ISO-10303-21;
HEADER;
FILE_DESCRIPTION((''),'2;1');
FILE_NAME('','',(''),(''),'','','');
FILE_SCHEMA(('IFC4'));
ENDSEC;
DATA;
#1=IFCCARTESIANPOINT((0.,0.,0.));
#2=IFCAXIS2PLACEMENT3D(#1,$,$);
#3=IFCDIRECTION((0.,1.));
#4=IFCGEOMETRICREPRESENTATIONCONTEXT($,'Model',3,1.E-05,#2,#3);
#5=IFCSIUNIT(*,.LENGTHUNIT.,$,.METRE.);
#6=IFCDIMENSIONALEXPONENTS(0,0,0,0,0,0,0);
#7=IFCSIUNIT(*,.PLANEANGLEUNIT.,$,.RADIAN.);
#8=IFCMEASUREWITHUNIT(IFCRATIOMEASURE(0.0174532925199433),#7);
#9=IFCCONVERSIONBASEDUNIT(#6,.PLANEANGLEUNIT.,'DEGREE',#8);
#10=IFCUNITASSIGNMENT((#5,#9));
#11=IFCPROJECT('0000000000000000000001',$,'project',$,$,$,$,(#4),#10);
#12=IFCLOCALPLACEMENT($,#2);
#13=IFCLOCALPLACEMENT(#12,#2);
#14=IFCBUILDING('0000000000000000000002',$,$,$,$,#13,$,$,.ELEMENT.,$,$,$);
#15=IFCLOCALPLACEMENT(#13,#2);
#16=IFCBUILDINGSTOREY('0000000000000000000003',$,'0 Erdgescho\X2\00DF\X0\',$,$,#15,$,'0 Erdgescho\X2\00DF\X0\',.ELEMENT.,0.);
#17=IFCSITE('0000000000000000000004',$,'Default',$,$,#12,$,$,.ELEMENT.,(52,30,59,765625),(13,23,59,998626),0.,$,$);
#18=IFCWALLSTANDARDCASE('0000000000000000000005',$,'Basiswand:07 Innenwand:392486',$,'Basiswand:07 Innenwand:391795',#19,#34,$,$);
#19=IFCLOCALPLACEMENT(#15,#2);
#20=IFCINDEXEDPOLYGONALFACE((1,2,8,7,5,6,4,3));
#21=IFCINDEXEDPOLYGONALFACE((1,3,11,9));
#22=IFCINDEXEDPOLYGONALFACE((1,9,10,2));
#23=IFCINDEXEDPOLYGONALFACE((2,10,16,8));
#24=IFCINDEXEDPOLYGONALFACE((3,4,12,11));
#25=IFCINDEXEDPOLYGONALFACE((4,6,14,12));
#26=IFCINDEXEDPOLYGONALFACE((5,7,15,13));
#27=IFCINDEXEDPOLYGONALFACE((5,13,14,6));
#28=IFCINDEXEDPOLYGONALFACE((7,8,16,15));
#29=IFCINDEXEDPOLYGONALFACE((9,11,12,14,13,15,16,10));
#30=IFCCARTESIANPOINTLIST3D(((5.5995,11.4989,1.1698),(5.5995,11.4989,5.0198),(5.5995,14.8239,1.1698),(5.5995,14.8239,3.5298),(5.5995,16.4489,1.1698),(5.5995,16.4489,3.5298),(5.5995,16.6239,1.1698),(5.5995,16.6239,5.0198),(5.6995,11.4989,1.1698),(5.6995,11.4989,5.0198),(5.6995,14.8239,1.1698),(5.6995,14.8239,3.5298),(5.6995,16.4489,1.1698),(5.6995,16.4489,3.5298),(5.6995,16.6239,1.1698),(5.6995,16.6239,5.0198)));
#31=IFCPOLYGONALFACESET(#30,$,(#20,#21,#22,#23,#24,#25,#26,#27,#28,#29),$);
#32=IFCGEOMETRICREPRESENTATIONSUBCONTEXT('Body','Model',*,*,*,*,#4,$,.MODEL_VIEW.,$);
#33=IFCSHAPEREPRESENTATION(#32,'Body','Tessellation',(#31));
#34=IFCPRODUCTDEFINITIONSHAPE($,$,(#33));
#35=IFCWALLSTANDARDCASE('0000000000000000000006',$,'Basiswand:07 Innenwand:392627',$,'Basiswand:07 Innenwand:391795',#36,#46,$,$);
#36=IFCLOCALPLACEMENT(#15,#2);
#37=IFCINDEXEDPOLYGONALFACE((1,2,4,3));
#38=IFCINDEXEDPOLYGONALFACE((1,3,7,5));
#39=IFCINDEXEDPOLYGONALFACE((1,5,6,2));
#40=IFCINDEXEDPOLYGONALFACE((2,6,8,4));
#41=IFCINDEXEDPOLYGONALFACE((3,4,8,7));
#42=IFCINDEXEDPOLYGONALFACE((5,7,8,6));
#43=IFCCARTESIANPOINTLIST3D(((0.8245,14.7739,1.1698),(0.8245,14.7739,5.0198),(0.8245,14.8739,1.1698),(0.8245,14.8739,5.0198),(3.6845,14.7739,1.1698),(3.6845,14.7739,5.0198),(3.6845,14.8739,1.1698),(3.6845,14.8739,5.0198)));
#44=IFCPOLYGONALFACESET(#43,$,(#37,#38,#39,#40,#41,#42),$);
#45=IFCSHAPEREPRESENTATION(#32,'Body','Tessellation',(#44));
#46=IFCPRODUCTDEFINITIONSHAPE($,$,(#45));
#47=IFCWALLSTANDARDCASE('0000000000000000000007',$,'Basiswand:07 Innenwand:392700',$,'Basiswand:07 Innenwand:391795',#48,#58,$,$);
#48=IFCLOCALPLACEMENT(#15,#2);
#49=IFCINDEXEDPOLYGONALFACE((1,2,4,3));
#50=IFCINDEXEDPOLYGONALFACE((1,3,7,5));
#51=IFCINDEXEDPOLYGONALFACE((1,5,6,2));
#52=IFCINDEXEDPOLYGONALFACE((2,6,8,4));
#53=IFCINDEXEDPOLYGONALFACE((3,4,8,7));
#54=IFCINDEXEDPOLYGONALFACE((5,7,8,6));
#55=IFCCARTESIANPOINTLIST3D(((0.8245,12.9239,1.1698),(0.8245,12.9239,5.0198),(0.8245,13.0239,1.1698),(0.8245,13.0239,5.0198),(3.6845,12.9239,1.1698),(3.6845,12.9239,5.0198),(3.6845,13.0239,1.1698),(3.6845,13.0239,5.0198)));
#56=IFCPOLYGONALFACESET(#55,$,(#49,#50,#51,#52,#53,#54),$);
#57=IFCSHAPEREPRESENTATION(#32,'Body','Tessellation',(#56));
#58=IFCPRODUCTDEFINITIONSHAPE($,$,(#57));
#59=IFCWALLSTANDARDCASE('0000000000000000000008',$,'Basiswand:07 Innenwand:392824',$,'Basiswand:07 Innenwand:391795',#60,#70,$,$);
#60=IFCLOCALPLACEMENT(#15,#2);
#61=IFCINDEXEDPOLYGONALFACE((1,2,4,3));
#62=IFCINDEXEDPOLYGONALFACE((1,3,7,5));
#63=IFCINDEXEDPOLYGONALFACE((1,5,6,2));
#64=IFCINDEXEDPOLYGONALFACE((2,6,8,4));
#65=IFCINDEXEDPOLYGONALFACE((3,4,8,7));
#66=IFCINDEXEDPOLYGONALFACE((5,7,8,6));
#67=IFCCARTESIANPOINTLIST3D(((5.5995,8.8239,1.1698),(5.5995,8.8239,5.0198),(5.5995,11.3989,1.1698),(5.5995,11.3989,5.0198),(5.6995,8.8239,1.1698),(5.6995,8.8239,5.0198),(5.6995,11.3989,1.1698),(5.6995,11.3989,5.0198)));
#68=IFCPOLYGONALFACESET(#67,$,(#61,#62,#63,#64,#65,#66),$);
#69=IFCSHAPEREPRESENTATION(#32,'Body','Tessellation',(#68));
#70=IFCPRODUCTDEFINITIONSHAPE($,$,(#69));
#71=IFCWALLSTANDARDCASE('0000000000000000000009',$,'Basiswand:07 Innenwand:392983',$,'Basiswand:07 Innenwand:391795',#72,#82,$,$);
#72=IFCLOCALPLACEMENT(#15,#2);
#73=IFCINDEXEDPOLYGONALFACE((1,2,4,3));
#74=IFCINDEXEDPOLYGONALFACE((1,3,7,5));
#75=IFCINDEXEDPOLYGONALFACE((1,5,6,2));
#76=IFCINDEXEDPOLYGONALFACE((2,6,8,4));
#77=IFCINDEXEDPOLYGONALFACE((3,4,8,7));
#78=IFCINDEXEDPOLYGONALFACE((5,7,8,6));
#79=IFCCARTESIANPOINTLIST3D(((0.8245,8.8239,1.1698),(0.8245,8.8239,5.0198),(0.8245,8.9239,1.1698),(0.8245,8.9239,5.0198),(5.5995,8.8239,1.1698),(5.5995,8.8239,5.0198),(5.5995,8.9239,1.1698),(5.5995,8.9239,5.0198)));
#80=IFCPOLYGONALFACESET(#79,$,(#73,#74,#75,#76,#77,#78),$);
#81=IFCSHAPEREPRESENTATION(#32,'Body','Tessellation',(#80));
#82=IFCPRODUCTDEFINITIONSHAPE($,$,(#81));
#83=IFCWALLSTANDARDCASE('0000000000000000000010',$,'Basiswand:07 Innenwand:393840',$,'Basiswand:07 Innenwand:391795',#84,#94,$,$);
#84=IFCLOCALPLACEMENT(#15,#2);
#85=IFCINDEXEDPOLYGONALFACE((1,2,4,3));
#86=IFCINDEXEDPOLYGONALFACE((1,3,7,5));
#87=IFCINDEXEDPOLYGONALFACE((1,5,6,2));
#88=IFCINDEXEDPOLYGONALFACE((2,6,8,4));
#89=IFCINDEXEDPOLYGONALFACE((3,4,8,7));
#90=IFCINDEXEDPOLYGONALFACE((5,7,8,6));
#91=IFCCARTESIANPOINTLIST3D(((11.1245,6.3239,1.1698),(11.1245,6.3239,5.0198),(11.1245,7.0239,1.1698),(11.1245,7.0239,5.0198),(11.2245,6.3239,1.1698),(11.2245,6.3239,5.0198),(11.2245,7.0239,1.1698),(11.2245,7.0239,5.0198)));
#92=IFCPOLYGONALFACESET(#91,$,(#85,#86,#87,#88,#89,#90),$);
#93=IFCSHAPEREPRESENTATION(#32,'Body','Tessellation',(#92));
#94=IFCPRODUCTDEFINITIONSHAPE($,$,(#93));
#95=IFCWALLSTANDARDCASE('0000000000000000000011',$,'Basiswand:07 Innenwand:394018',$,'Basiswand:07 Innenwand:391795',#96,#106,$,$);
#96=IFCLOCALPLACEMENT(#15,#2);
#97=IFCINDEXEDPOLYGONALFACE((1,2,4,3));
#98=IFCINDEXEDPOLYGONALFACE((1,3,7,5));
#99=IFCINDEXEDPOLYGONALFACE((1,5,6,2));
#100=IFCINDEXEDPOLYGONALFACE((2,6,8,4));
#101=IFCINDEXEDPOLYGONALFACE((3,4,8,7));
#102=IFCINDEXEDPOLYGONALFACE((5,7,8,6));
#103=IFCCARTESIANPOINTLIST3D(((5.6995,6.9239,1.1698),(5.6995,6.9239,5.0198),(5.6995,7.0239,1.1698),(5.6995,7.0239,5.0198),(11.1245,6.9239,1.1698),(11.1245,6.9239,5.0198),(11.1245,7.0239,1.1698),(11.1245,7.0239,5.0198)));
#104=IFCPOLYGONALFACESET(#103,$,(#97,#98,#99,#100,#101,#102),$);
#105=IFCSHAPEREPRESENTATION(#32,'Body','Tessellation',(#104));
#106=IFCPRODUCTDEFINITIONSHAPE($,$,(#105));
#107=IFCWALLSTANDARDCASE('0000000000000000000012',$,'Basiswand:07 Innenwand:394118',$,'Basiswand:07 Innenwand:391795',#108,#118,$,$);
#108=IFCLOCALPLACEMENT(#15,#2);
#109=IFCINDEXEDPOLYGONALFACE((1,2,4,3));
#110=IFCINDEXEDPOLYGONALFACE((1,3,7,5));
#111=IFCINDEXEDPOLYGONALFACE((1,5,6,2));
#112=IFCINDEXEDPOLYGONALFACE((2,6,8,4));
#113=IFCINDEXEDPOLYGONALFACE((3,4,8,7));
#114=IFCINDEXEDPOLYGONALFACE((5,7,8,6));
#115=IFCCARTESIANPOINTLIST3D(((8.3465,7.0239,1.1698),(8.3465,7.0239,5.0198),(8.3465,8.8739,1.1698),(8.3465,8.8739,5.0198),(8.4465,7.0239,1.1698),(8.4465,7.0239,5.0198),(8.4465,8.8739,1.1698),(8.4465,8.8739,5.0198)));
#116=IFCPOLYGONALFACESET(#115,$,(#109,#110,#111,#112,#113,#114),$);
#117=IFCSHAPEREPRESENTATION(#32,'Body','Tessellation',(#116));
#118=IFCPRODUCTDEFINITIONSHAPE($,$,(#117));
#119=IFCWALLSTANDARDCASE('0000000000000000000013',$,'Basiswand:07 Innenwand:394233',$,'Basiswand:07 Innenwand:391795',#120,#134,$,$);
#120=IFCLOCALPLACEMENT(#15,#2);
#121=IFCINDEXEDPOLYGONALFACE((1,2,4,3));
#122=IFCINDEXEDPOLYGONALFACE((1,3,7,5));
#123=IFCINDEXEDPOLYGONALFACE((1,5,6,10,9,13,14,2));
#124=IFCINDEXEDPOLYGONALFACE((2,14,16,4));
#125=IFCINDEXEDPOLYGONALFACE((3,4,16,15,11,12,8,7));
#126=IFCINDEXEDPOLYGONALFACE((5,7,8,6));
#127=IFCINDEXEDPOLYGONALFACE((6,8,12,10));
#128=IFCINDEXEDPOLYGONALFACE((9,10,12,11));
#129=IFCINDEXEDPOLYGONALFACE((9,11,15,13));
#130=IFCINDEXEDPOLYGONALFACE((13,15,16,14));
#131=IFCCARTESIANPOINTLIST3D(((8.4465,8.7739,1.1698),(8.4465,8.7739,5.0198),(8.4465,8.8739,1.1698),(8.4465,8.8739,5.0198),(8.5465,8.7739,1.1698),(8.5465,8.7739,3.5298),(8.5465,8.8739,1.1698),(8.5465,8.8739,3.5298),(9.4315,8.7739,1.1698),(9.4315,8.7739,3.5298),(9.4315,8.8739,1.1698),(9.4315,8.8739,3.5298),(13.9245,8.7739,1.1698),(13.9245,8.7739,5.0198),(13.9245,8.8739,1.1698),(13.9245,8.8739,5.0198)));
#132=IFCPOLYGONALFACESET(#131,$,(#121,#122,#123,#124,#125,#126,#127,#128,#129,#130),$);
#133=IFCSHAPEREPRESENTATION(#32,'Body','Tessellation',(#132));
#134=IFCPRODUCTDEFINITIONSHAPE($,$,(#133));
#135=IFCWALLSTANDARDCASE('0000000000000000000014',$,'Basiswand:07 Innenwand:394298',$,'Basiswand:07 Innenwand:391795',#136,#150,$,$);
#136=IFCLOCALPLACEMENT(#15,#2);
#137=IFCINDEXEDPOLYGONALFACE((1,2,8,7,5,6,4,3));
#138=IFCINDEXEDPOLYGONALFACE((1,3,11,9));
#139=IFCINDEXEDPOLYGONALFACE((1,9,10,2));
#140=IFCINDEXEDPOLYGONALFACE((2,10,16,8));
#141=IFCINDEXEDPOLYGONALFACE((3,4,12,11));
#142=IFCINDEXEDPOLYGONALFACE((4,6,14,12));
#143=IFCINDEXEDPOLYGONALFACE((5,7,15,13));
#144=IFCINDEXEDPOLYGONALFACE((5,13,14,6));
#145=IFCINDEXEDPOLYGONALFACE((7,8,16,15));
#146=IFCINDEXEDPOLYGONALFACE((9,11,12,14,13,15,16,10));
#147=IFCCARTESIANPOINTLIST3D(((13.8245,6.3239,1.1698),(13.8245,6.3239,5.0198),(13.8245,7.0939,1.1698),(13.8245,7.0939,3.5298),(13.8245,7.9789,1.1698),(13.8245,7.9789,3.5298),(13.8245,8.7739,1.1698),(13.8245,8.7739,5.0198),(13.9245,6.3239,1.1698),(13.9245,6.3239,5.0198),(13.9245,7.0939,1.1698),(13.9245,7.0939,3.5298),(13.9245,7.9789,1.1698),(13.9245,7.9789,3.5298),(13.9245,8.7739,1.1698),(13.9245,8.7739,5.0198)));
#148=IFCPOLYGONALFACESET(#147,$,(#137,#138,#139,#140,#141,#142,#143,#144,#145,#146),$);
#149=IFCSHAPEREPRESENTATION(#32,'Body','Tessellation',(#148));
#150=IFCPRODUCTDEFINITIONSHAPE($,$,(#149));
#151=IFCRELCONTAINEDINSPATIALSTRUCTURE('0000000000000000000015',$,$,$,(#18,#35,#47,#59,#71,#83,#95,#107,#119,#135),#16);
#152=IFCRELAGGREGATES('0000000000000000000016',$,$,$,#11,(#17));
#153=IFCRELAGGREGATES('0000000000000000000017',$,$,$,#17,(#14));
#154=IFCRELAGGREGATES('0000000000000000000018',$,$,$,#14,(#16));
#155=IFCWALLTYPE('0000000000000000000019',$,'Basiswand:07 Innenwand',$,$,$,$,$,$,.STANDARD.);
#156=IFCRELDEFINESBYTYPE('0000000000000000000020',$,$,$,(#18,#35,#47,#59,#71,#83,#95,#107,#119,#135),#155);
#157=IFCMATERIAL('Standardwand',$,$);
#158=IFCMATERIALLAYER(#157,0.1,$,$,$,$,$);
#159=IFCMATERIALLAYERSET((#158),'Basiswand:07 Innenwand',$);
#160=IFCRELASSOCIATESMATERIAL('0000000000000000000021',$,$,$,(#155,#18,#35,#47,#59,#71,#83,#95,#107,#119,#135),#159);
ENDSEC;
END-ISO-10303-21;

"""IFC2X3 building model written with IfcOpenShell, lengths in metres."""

from ifc_helpers import new_model, entity, si_unit, converted_unit, direction, frame, frame_2d, origin, place, context, subcontext, project, spatial, polyline, rectangle, extrude, clip, bounded_halfspace, material, layer, layer_set, layer_usage, type_object, element, save


model = new_model("IFC2X3")

# Units and contexts
model_context = context("Model", 3, precision=1e-05, world=origin(), true_north=direction((0.0, 1.0)))
body_context = subcontext(model_context, "Body", "Model", "MODEL_VIEW")
ifc_project = project(units=[si_unit("LENGTHUNIT", "METRE"), converted_unit("PLANEANGLEUNIT", "DEGREE", entity("IfcRatioMeasure", 0.0174532925199433), si_unit("PLANEANGLEUNIT", "RADIAN"), dimensions=[0, 0, 0, 0, 0, 0, 0])], contexts=[model_context])

# Site, building, storey
site_placement = place(None, origin())
site = spatial("IfcSite", under=ifc_project, at=site_placement, Name="Default", CompositionType="ELEMENT", RefLatitude=(52, 30, 59, 765625), RefLongitude=(13, 23, 59, 998626), RefElevation=0.0)
building_placement = place(site_placement, origin())
building = spatial("IfcBuilding", under=site, at=building_placement, CompositionType="ELEMENT")
storey_placement = place(building_placement, origin())
storey = spatial("IfcBuildingStorey", under=building, at=storey_placement, Name="0 Erdgeschoß", LongName="0 Erdgeschoß", CompositionType="ELEMENT", Elevation=0.0)

# Shared definitions
ifc_material_1 = material(Name="Standardwand")
ifc_layer_1 = layer(ifc_material_1, 0.1)
ifc_layer_set_1 = layer_set([ifc_layer_1], Name="Basiswand:07 Innenwand")
wall_type_1 = type_object("IfcWallType", Name="Basiswand:07 Innenwand", PredefinedType="STANDARD", material=ifc_layer_set_1)

# Wall, opening
ifc_layer_usage_1 = layer_usage(ifc_layer_set_1, "AXIS2", "POSITIVE", -0.05)
wall_1_placement = place(storey_placement, frame((5.6495, 11.4989, 1.1698), z_axis=(0.0, 0.0, 1.0), x_axis=(0.0, 1.0, 0.0)))
wall_1 = element("IfcWallStandardCase", 1, at=wall_1_placement, inside=storey, type_object=wall_type_1, material=ifc_layer_usage_1, Name="Basiswand:07 Innenwand:392486", ObjectType="Basiswand:07 Innenwand:391795", context=body_context, shape_type="Clipping", body=[
    clip(extrude(rectangle(XDim=5.125, YDim=0.1, at=frame_2d((2.5625, 0.0), x_axis=(-1.0, 0.0))), origin(), (0.0, 0.0, 1.0), 3.85), bounded_halfspace(frame((0.0, -0.05, 3.85), z_axis=(0.0, 0.0, -1.0), x_axis=(-1.0, 0.0, 0.0)), True, frame((0.0, -0.05, 3.85)), polyline([(0.0, 0.0), (5.125, 0.0), (5.125, 0.1), (2.125, 0.1), (2.025, 0.1), (0.0, 0.1), (0.0, 0.0)]))),
])
opening_1_placement = place(wall_1_placement, frame((4.95, 0.05, 0.0)))
element("IfcOpeningElement", 2, at=opening_1_placement, cuts=wall_1, ObjectType="Opening", context=body_context, shape_type="SweptSolid", body=[
    extrude(rectangle(XDim=2.36, YDim=1.625, at=frame_2d((1.18, 0.8125), x_axis=(1.0, 0.0))), frame((0.0, 0.0, 0.0), z_axis=(0.0, -1.0, 0.0), x_axis=(0.0, 0.0, 1.0)), (0.0, 0.0, 1.0), 0.1),
])

# Walls
ifc_layer_usage_2 = layer_usage(ifc_layer_set_1, "AXIS2", "NEGATIVE", 0.05)
wall_2_placement = place(storey_placement, frame((3.6845, 14.8239, 1.1698), z_axis=(0.0, 0.0, 1.0), x_axis=(-1.0, 0.0, 0.0)))
element("IfcWallStandardCase", 3, at=wall_2_placement, inside=storey, type_object=wall_type_1, material=ifc_layer_usage_2, Name="Basiswand:07 Innenwand:392627", ObjectType="Basiswand:07 Innenwand:391795", context=body_context, shape_type="Clipping", body=[
    clip(extrude(rectangle(XDim=2.86, YDim=0.1, at=frame_2d((1.43, 0.0), x_axis=(-1.0, 0.0))), origin(), (0.0, 0.0, 1.0), 3.85), bounded_halfspace(frame((0.0, -0.05, 3.85), z_axis=(0.0, 0.0, -1.0), x_axis=(0.0, 1.0, 0.0)), True, frame((0.0, -0.05, 3.85)), polyline([(0.0, 0.0), (2.86, 0.0), (2.86, 0.1), (0.0, 0.1), (0.0, 0.0)]))),
])
ifc_layer_usage_3 = layer_usage(ifc_layer_set_1, "AXIS2", "NEGATIVE", 0.05)
wall_3_placement = place(storey_placement, frame((3.6845, 12.9739, 1.1698), z_axis=(0.0, 0.0, 1.0), x_axis=(-1.0, 0.0, 0.0)))
element("IfcWallStandardCase", 4, at=wall_3_placement, inside=storey, type_object=wall_type_1, material=ifc_layer_usage_3, Name="Basiswand:07 Innenwand:392700", ObjectType="Basiswand:07 Innenwand:391795", context=body_context, shape_type="Clipping", body=[
    clip(extrude(rectangle(XDim=2.86, YDim=0.1, at=frame_2d((1.43, 0.0), x_axis=(-1.0, 0.0))), origin(), (0.0, 0.0, 1.0), 3.85), bounded_halfspace(frame((0.0, -0.05, 3.85), z_axis=(0.0, 0.0, -1.0), x_axis=(0.0, 1.0, 0.0)), True, frame((0.0, -0.05, 3.85)), polyline([(0.0, 0.0), (2.86, 0.0), (2.86, 0.1), (0.0, 0.1), (0.0, 0.0)]))),
])
ifc_layer_usage_4 = layer_usage(ifc_layer_set_1, "AXIS2", "POSITIVE", -0.05)
wall_4_placement = place(storey_placement, frame((5.6495, 11.3989, 1.1698), z_axis=(0.0, 0.0, 1.0), x_axis=(0.0, -1.0, 0.0)))
element("IfcWallStandardCase", 5, at=wall_4_placement, inside=storey, type_object=wall_type_1, material=ifc_layer_usage_4, Name="Basiswand:07 Innenwand:392824", ObjectType="Basiswand:07 Innenwand:391795", context=body_context, shape_type="Clipping", body=[
    clip(extrude(rectangle(XDim=2.575, YDim=0.1, at=frame_2d((1.2875, 0.0), x_axis=(-1.0, 0.0))), origin(), (0.0, 0.0, 1.0), 3.85), bounded_halfspace(frame((0.0, -0.05, 3.85), z_axis=(0.0, 0.0, -1.0), x_axis=(1.0, 0.0, 0.0)), True, frame((0.0, -0.05, 3.85)), polyline([(0.0, 0.0), (2.475, 0.0), (2.575, 0.0), (2.575, 0.1), (0.0, 0.1), (0.0, 0.0)]))),
])
ifc_layer_usage_5 = layer_usage(ifc_layer_set_1, "AXIS2", "POSITIVE", -0.05)
wall_5_placement = place(storey_placement, frame((5.5995, 8.8739, 1.1698), z_axis=(0.0, 0.0, 1.0), x_axis=(-1.0, 0.0, 0.0)))
element("IfcWallStandardCase", 6, at=wall_5_placement, inside=storey, type_object=wall_type_1, material=ifc_layer_usage_5, Name="Basiswand:07 Innenwand:392983", ObjectType="Basiswand:07 Innenwand:391795", context=body_context, shape_type="Clipping", body=[
    clip(extrude(rectangle(XDim=4.775, YDim=0.1, at=frame_2d((2.3875, 0.0), x_axis=(-1.0, 0.0))), origin(), (0.0, 0.0, 1.0), 3.85), bounded_halfspace(frame((0.0, -0.05, 3.85), z_axis=(0.0, 0.0, -1.0), x_axis=(0.0, 1.0, 0.0)), True, frame((0.0, -0.05, 3.85)), polyline([(0.0, 0.0), (4.775, 0.0), (4.775, 0.1), (1.915, 0.1), (1.815, 0.1), (0.0, 0.1), (0.0, 0.0)]))),
])
ifc_layer_usage_6 = layer_usage(ifc_layer_set_1, "AXIS2", "NEGATIVE", 0.05)
wall_6_placement = place(storey_placement, frame((11.1745, 6.3239, 1.1698), z_axis=(0.0, 0.0, 1.0), x_axis=(0.0, 1.0, 0.0)))
element("IfcWallStandardCase", 7, at=wall_6_placement, inside=storey, type_object=wall_type_1, material=ifc_layer_usage_6, Name="Basiswand:07 Innenwand:393840", ObjectType="Basiswand:07 Innenwand:391795", context=body_context, shape_type="Clipping", body=[
    clip(extrude(rectangle(XDim=0.7, YDim=0.1, at=frame_2d((0.35, 0.0), x_axis=(-1.0, 0.0))), origin(), (0.0, 0.0, 1.0), 3.85), bounded_halfspace(frame((0.0, -0.05, 3.85), z_axis=(0.0, 0.0, -1.0), x_axis=(-1.0, 0.0, 0.0)), True, frame((0.0, -0.05, 3.85)), polyline([(0.0, 0.0), (0.7, 0.0), (0.7, 0.1), (0.6, 0.1), (0.0, 0.1), (0.0, 0.0)]))),
])
ifc_layer_usage_7 = layer_usage(ifc_layer_set_1, "AXIS2", "NEGATIVE", 0.05)
wall_7_placement = place(storey_placement, frame((11.1245, 6.9739, 1.1698), z_axis=(0.0, 0.0, 1.0), x_axis=(-1.0, 0.0, 0.0)))
element("IfcWallStandardCase", 8, at=wall_7_placement, inside=storey, type_object=wall_type_1, material=ifc_layer_usage_7, Name="Basiswand:07 Innenwand:394018", ObjectType="Basiswand:07 Innenwand:391795", context=body_context, shape_type="Clipping", body=[
    clip(extrude(rectangle(XDim=5.425, YDim=0.1, at=frame_2d((2.7125, 0.0), x_axis=(-1.0, 0.0))), origin(), (0.0, 0.0, 1.0), 3.85), bounded_halfspace(frame((0.0, -0.05, 3.85), z_axis=(0.0, 0.0, -1.0), x_axis=(0.0, 1.0, 0.0)), True, frame((0.0, -0.05, 3.85)), polyline([(0.0, 0.0), (2.6781, 0.0), (2.7781, 0.0), (5.425, 0.0), (5.425, 0.1), (2.175, 0.1), (2.075, 0.1), (0.0, 0.1), (0.0, 0.0)]))),
])
ifc_layer_usage_8 = layer_usage(ifc_layer_set_1, "AXIS2", "NEGATIVE", 0.05)
wall_8_placement = place(storey_placement, frame((8.3965, 7.0239, 1.1698), z_axis=(0.0, 0.0, 1.0), x_axis=(0.0, 1.0, 0.0)))
element("IfcWallStandardCase", 9, at=wall_8_placement, inside=storey, type_object=wall_type_1, material=ifc_layer_usage_8, Name="Basiswand:07 Innenwand:394118", ObjectType="Basiswand:07 Innenwand:391795", context=body_context, shape_type="Clipping", body=[
    clip(extrude(rectangle(XDim=1.85, YDim=0.1, at=frame_2d((0.925, 0.0), x_axis=(-1.0, 0.0))), origin(), (0.0, 0.0, 1.0), 3.85), bounded_halfspace(frame((0.0, -0.05, 3.85), z_axis=(0.0, 0.0, -1.0), x_axis=(-1.0, 0.0, 0.0)), True, frame((0.0, -0.05, 3.85)), polyline([(0.0, 0.0), (1.75, 0.0), (1.85, 0.0), (1.85, 0.1), (0.0, 0.1), (0.0, 0.0)]))),
])

# Walls, openings
ifc_layer_usage_9 = layer_usage(ifc_layer_set_1, "AXIS2", "NEGATIVE", 0.05)
wall_9_placement = place(storey_placement, frame((8.4465, 8.8239, 1.1698), z_axis=(0.0, 0.0, 1.0), x_axis=(1.0, 0.0, 0.0)))
wall_9 = element("IfcWallStandardCase", 10, at=wall_9_placement, inside=storey, type_object=wall_type_1, material=ifc_layer_usage_9, Name="Basiswand:07 Innenwand:394233", ObjectType="Basiswand:07 Innenwand:391795", context=body_context, shape_type="Clipping", body=[
    clip(extrude(rectangle(XDim=5.4781, YDim=0.1, at=frame_2d((2.739, 0.0), x_axis=(-1.0, 0.0))), origin(), (0.0, 0.0, 1.0), 3.85), bounded_halfspace(frame((0.0, -0.05, 3.85), z_axis=(0.0, 0.0, -1.0), x_axis=(0.0, -1.0, 0.0)), True, frame((0.0, -0.05, 3.85)), polyline([(0.0, 0.0), (5.3781, 0.0), (5.4781, 0.0), (5.4781, 0.1), (5.3781, 0.1), (0.0, 0.1), (0.0, 0.0)]))),
])
opening_2_placement = place(wall_9_placement, frame((0.985, 0.05, 0.0)))
element("IfcOpeningElement", 11, at=opening_2_placement, cuts=wall_9, ObjectType="Opening", context=body_context, shape_type="SweptSolid", body=[
    extrude(rectangle(XDim=2.36, YDim=0.885, at=frame_2d((1.18, 0.4425), x_axis=(1.0, 0.0))), frame((0.0, 0.0, 0.0), z_axis=(0.0, -1.0, 0.0), x_axis=(0.0, 0.0, 1.0)), (0.0, 0.0, 1.0), 0.1),
])
ifc_layer_usage_10 = layer_usage(ifc_layer_set_1, "AXIS2", "NEGATIVE", 0.05)
wall_10_placement = place(storey_placement, frame((13.8745, 8.7739, 1.1698), z_axis=(0.0, 0.0, 1.0), x_axis=(0.0, -1.0, 0.0)))
wall_10 = element("IfcWallStandardCase", 12, at=wall_10_placement, inside=storey, type_object=wall_type_1, material=ifc_layer_usage_10, Name="Basiswand:07 Innenwand:394298", ObjectType="Basiswand:07 Innenwand:391795", context=body_context, shape_type="Clipping", body=[
    clip(extrude(rectangle(XDim=2.45, YDim=0.1, at=frame_2d((1.225, 0.0), x_axis=(-1.0, 0.0))), origin(), (0.0, 0.0, 1.0), 3.85), bounded_halfspace(frame((0.0, -0.05, 3.85), z_axis=(0.0, 0.0, -1.0), x_axis=(1.0, 0.0, 0.0)), True, frame((0.0, -0.05, 3.85)), polyline([(0.0, 0.0), (2.45, 0.0), (2.45, 0.1), (0.0, 0.1), (0.0, 0.0)]))),
])
opening_3_placement = place(wall_10_placement, frame((1.68, 0.05, 0.0)))
element("IfcOpeningElement", 13, at=opening_3_placement, cuts=wall_10, ObjectType="Opening", context=body_context, shape_type="SweptSolid", body=[
    extrude(rectangle(XDim=2.36, YDim=0.885, at=frame_2d((1.18, 0.4425), x_axis=(1.0, 0.0))), frame((0.0, 0.0, 0.0), z_axis=(0.0, -1.0, 0.0), x_axis=(0.0, 0.0, 1.0)), (0.0, 0.0, 1.0), 0.1),
])

save(model, "model.ifc")
